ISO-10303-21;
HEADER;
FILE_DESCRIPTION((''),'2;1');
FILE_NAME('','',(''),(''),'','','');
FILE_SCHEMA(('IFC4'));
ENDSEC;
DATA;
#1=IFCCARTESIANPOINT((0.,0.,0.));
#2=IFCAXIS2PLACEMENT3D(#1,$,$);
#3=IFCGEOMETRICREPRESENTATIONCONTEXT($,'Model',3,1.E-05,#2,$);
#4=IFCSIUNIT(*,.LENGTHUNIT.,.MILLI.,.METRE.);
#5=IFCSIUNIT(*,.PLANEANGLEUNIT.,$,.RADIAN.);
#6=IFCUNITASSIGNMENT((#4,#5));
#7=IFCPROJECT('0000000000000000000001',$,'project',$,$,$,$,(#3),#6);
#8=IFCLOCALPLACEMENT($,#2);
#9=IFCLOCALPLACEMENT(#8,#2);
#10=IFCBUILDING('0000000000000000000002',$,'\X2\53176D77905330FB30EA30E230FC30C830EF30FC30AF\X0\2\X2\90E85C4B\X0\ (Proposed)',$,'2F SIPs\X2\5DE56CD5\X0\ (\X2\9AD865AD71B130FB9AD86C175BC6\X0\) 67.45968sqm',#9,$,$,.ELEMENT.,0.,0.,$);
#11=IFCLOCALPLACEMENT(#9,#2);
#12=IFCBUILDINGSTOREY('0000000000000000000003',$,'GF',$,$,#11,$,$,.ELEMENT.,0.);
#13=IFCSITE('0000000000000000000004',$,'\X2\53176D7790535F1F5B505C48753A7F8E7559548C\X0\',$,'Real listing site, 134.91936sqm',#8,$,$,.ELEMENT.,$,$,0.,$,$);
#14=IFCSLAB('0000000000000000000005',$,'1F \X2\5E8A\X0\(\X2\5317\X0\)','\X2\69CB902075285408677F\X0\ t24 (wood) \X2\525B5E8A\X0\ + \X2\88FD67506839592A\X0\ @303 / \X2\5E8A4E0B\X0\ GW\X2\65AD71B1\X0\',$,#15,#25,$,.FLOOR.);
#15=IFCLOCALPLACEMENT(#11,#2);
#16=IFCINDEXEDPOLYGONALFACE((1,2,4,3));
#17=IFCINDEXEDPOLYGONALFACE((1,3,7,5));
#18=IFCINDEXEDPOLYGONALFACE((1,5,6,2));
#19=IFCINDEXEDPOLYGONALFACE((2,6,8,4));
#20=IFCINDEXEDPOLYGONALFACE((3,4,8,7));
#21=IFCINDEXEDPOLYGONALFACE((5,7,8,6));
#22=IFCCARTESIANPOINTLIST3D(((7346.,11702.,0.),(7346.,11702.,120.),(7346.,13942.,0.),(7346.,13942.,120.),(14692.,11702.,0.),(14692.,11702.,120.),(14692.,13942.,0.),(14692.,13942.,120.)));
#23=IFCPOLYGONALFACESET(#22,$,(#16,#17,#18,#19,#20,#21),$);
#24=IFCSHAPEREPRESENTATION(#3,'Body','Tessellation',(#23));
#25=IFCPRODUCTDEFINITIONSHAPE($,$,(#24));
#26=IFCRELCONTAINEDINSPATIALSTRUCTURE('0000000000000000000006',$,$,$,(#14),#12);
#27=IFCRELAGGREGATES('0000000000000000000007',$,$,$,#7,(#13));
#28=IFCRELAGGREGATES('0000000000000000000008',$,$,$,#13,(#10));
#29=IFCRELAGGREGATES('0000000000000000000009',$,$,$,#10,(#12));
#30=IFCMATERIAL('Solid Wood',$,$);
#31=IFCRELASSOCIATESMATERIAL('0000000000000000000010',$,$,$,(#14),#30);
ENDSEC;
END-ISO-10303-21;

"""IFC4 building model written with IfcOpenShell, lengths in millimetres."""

from ifc_helpers import new_model, si_unit, frame, frame_2d, origin, place, context, project, spatial, rectangle, extrude, material, element, save


model = new_model("IFC4")

# Units and contexts
model_context = context("Model", 3, precision=1e-05, world=origin())
ifc_project = project(units=[si_unit("LENGTHUNIT", "METRE", prefix="MILLI"), si_unit("PLANEANGLEUNIT", "RADIAN")], contexts=[model_context])

# Site, building, storey
site_placement = place(None, origin())
site = spatial("IfcSite", under=ifc_project, at=site_placement, Name="北海道弟子屈町美留和", ObjectType="Real listing site, 134.91936sqm", CompositionType="ELEMENT", RefElevation=0.0)
building_placement = place(site_placement, origin())
building = spatial("IfcBuilding", under=site, at=building_placement, Name="北海道・リモートワーク2部屋 (Proposed)", ObjectType="2F SIPs工法 (高断熱・高気密) 67.45968sqm", CompositionType="ELEMENT", ElevationOfRefHeight=0.0, ElevationOfTerrain=0.0)
storey_placement = place(building_placement, origin())
storey = spatial("IfcBuildingStorey", under=building, at=storey_placement, Name="GF", CompositionType="ELEMENT", Elevation=0.0)

# Slab
ifc_material_1 = material(Name="Solid Wood")
slab_1_placement = place(storey_placement, frame((3673.0, 5851.0, 0.0)))
element("IfcSlab", 1, at=slab_1_placement, inside=storey, material=ifc_material_1, Name="1F 床(北)", Description="構造用合板 t24 (wood) 剛床 + 製材根太 @303 / 床下 GW断熱", PredefinedType="FLOOR", context=model_context, shape_type="SweptSolid", body=[
    extrude(rectangle(XDim=7346.0, YDim=2240.0, at=frame_2d((3673.0, 1120.0))), frame((3673.0, 5851.0, 0.0)), (0.0, 0.0, 1.0), 120.0),
])

save(model, "model.ifc")
